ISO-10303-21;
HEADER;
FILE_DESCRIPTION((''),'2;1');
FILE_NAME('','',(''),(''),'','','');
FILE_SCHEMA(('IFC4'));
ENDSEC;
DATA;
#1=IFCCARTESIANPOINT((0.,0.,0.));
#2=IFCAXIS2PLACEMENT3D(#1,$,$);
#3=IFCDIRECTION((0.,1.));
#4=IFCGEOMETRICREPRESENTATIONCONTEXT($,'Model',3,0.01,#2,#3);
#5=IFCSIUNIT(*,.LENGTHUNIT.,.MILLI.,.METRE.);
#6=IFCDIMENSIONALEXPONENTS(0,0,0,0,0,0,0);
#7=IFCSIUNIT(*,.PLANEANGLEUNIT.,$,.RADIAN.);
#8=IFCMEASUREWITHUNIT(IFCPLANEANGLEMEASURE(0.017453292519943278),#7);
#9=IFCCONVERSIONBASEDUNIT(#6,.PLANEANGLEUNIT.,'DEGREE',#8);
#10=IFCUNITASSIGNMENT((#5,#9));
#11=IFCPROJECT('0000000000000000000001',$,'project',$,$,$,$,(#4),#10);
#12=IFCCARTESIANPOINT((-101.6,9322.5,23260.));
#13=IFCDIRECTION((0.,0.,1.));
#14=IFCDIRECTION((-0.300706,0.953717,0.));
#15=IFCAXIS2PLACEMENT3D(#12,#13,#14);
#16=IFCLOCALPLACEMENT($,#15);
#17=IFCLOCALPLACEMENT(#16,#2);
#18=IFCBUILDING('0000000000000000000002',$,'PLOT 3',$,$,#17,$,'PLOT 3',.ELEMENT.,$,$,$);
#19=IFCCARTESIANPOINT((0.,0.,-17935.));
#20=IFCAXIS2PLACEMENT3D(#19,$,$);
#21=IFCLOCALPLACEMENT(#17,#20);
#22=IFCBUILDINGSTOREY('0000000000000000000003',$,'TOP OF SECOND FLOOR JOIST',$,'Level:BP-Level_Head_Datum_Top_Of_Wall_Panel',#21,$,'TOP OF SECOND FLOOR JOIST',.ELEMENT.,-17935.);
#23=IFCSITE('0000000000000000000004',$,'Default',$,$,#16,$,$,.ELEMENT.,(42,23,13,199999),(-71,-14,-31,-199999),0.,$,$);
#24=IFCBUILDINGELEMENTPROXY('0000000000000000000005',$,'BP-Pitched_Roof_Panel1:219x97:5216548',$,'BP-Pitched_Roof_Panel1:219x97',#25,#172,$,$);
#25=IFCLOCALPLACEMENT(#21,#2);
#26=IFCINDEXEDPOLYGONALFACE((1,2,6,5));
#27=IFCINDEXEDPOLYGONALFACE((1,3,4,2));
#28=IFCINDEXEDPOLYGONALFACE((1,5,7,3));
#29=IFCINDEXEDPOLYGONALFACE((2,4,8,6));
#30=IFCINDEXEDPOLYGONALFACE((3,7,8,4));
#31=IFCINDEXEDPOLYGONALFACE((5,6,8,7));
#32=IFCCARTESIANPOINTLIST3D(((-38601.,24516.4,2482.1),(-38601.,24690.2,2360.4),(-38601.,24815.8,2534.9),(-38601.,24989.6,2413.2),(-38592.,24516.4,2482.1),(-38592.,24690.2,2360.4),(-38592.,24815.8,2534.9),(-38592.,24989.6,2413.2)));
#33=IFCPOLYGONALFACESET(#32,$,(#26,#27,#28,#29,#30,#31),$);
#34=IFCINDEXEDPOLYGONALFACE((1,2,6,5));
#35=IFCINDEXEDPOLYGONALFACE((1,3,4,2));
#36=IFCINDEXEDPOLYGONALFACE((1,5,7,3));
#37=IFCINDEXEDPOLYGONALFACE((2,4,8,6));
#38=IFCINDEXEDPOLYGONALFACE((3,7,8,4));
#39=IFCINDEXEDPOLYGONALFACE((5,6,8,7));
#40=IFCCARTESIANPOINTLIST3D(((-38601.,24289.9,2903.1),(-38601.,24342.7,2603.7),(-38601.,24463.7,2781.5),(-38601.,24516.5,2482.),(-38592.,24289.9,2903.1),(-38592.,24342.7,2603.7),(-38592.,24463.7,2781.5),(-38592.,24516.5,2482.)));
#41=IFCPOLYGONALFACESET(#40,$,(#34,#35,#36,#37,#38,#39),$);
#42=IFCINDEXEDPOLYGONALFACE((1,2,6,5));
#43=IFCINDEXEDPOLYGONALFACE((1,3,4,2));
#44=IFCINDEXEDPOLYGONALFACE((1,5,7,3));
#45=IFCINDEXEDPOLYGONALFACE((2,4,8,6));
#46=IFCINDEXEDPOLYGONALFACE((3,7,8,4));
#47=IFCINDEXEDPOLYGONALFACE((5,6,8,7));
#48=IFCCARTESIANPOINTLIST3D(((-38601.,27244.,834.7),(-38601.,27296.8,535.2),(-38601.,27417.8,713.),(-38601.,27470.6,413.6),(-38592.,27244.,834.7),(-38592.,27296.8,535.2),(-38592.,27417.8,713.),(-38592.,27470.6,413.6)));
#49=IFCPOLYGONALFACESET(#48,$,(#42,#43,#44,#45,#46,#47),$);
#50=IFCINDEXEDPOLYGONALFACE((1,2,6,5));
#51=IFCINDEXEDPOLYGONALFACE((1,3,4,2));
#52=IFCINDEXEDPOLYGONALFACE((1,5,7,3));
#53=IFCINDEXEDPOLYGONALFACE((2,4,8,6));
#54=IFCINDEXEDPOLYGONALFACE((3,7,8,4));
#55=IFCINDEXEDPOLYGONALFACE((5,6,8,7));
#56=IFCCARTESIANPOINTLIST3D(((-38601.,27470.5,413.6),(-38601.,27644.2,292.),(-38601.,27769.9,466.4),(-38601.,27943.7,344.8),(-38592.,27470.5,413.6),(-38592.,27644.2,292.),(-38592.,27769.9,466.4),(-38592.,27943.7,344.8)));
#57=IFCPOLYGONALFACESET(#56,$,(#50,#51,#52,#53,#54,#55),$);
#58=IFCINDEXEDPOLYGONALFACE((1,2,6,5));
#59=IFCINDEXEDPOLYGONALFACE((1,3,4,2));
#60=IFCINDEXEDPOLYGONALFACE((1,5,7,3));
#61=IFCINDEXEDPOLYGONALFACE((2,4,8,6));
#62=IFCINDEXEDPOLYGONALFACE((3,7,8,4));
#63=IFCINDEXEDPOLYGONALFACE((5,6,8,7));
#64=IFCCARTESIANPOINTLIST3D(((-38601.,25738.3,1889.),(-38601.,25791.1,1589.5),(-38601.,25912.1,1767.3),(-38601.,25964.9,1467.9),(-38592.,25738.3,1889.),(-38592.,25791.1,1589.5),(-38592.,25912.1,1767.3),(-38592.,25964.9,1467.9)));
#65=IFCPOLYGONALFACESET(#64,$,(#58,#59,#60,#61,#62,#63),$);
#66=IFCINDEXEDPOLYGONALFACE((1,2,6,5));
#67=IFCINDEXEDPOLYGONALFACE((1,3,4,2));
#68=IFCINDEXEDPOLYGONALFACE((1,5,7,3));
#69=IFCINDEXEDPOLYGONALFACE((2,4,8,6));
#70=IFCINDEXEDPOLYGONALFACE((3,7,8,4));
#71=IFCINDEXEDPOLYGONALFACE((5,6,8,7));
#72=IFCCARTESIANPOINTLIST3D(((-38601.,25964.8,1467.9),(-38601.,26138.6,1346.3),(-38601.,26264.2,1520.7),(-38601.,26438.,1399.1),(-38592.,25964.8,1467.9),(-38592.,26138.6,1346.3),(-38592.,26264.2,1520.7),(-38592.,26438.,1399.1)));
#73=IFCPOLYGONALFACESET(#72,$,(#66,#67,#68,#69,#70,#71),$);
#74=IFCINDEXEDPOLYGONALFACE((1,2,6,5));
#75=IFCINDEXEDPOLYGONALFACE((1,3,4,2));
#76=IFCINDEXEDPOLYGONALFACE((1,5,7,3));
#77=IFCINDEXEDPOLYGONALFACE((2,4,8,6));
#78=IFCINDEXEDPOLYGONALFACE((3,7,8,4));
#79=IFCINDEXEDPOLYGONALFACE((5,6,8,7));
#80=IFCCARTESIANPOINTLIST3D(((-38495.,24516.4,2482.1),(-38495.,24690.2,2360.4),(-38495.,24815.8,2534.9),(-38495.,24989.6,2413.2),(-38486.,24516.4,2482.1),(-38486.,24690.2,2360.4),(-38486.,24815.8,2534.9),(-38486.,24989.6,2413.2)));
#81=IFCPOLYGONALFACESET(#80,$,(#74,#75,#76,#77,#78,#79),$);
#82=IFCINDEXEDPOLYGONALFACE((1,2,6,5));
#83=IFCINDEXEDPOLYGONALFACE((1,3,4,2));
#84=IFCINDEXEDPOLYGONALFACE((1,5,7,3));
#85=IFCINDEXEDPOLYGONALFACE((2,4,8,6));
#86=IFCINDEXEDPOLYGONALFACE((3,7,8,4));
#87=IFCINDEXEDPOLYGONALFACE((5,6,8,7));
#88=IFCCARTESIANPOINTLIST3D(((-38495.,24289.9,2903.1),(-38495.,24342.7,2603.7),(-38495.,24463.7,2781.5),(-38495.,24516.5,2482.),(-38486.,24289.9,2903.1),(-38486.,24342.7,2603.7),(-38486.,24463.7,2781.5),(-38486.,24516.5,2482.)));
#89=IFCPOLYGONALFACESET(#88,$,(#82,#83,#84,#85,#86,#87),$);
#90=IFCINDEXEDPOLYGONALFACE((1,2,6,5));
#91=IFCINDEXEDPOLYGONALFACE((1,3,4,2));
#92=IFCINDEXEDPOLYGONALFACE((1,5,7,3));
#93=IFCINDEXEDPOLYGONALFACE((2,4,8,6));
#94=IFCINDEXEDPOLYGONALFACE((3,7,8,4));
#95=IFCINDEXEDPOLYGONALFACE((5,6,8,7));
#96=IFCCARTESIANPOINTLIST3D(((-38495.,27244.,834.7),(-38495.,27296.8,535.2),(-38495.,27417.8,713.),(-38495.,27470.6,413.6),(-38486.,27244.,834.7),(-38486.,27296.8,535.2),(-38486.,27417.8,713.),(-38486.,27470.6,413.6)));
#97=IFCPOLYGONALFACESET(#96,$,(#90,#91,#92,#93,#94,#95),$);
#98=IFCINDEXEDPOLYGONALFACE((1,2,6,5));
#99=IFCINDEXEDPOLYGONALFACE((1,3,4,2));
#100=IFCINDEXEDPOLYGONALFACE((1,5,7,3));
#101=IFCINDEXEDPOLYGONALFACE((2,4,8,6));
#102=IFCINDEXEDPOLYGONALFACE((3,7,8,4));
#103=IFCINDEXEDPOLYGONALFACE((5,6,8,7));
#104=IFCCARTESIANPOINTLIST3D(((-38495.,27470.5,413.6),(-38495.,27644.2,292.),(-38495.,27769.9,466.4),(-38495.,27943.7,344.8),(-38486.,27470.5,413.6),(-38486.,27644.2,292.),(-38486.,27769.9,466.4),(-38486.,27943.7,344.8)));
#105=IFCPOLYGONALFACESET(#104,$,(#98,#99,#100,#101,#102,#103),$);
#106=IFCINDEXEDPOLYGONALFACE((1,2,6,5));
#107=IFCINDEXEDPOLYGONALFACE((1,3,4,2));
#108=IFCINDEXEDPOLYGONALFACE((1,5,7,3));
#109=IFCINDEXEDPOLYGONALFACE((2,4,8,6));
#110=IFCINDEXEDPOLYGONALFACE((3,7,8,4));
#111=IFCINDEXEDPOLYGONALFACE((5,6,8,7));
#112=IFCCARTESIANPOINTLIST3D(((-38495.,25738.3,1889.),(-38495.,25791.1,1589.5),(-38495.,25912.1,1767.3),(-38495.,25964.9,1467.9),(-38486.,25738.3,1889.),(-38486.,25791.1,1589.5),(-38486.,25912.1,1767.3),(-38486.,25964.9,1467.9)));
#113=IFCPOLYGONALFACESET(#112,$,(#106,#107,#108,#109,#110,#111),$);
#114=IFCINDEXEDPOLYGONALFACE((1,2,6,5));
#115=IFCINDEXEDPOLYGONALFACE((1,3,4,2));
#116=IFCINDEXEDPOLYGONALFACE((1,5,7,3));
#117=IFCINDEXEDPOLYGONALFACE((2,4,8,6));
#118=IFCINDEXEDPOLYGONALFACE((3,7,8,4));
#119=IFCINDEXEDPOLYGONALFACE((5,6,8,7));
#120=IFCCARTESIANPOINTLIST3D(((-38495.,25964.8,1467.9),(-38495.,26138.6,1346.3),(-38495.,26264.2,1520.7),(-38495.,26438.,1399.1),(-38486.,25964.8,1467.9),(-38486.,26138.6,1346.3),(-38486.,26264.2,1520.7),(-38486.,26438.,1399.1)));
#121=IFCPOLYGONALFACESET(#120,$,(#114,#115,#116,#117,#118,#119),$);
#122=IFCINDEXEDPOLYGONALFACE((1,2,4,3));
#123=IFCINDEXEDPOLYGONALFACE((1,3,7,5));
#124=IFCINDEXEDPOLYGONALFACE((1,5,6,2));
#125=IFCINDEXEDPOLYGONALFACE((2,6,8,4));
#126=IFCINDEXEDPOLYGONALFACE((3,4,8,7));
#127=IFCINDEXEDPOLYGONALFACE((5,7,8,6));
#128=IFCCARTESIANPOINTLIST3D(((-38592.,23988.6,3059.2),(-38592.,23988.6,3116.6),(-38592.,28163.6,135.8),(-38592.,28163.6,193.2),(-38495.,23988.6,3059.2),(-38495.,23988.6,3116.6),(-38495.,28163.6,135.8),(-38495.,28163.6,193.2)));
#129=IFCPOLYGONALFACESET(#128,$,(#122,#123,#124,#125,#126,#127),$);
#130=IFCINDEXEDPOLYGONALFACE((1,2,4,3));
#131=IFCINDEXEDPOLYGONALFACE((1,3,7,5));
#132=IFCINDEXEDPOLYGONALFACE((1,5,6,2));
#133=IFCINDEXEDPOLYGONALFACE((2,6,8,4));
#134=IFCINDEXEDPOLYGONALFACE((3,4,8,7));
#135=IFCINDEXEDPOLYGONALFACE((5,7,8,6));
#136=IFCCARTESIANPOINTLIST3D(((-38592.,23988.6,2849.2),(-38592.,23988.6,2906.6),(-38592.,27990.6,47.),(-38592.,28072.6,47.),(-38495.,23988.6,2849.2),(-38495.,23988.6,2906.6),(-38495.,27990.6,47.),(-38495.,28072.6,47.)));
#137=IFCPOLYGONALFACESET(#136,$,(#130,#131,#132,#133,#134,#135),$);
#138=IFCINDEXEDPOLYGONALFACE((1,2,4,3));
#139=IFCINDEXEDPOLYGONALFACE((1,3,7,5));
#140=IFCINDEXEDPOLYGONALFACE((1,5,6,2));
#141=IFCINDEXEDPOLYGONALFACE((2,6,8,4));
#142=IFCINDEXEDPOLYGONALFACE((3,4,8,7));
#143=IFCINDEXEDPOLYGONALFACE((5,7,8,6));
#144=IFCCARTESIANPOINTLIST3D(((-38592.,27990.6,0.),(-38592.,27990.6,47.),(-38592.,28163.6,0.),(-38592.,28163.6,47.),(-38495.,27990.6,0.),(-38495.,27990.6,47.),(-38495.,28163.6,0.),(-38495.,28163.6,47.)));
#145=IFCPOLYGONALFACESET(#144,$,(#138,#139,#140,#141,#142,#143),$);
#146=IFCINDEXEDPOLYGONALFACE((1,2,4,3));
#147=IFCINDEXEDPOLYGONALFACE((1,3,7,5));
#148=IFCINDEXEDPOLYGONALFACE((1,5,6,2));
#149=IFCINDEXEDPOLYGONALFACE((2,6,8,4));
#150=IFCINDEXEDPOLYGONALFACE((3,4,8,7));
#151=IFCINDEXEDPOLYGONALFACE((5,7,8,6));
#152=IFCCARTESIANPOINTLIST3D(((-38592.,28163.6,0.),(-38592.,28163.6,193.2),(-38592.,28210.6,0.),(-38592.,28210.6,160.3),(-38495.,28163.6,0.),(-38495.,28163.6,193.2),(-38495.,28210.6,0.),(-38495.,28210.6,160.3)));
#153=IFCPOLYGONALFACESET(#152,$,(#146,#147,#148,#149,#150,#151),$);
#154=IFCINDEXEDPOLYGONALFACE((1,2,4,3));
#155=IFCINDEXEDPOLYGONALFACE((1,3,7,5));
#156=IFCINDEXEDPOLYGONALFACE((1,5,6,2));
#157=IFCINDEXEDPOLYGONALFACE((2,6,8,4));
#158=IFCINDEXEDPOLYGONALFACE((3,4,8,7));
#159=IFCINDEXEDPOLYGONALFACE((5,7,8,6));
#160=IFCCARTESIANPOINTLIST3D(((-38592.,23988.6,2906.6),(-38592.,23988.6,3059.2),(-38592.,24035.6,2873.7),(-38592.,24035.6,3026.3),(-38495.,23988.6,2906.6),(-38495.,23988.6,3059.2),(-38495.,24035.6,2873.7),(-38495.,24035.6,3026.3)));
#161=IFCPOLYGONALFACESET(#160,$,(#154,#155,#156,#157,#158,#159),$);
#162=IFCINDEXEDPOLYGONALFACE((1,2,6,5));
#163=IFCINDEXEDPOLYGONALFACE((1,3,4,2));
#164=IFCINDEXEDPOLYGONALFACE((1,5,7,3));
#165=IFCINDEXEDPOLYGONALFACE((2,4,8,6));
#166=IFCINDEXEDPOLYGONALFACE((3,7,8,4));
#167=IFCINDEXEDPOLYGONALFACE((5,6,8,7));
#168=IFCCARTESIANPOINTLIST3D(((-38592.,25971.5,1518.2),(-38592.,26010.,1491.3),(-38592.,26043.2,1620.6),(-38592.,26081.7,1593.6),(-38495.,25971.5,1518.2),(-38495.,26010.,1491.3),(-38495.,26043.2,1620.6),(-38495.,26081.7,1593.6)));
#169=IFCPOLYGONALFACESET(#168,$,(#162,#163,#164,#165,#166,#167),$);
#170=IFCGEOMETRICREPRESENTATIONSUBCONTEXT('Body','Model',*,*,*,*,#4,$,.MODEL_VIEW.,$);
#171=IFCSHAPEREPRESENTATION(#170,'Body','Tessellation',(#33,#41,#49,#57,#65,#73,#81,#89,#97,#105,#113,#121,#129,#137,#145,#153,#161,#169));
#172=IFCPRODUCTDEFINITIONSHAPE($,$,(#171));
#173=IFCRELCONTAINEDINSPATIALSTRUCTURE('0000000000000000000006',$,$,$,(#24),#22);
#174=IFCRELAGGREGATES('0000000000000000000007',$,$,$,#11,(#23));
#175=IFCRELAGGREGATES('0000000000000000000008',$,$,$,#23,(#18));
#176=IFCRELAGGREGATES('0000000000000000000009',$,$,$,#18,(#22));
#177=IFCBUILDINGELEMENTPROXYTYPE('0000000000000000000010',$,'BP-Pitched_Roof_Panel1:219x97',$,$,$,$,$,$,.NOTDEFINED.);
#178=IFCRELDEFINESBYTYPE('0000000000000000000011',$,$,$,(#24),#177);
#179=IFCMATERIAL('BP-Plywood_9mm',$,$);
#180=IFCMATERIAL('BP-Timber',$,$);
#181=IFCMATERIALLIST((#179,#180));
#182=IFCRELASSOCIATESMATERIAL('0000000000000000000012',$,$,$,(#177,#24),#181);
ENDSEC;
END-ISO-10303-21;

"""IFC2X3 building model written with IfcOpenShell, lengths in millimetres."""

from ifc_helpers import new_model, entity, si_unit, converted_unit, direction, frame, frame_2d, origin, origin_2d_with_axis, place, context, subcontext, project, spatial, polyline, rectangle, outline, extrude, source, transform, mapped, material, material_list, type_object, type_shapes, element, save


model = new_model("IFC2X3")

# Units and contexts
model_context = context("Model", 3, precision=0.01, world=origin(), true_north=direction((0.0, 1.0)))
body_context = subcontext(model_context, "Body", "Model", "MODEL_VIEW")
ifc_project = project(units=[si_unit("LENGTHUNIT", "METRE", prefix="MILLI"), converted_unit("PLANEANGLEUNIT", "DEGREE", entity("IfcPlaneAngleMeasure", 0.017453292519943278), si_unit("PLANEANGLEUNIT", "RADIAN"), dimensions=[0, 0, 0, 0, 0, 0, 0])], contexts=[model_context])

# Site, building, storey
site_placement = place(None, frame((-101.6, 9322.5, 23260.0), z_axis=(0.0, 0.0, 1.0), x_axis=(-0.300706, 0.953717, 0.0)))
site = spatial("IfcSite", under=ifc_project, at=site_placement, Name="Default", CompositionType="ELEMENT", RefLatitude=(42, 23, 13, 199999), RefLongitude=(-71, -14, -31, -199999), RefElevation=0.0)
building_placement = place(site_placement, origin())
building = spatial("IfcBuilding", under=site, at=building_placement, Name="PLOT 3", LongName="PLOT 3", CompositionType="ELEMENT")
storey_placement = place(building_placement, frame((0.0, 0.0, -17935.0)))
storey = spatial("IfcBuildingStorey", under=building, at=storey_placement, Name="TOP OF SECOND FLOOR JOIST", ObjectType="Level:BP-Level_Head_Datum_Top_Of_Wall_Panel", LongName="TOP OF SECOND FLOOR JOIST", CompositionType="ELEMENT", Elevation=-17935.0)

# Building element proxy
ifc_material_1 = material(Name="BP-Timber")
ifc_material_2 = material(Name="BP-Plywood_9mm")
ifc_material_list = material_list([ifc_material_2, ifc_material_1])
building_element_proxy_type_1 = type_object("IfcBuildingElementProxyType", Name="BP-Pitched_Roof_Panel1:219x97", PredefinedType="NOTDEFINED", material=ifc_material_list)
shared_shape_1 = source(origin(), body_context, "Body", "SweptSolid", [
    extrude(outline(polyline([(-77.0, -75.0), (227.0, -75.0), (77.0, 75.0), (-227.0, 75.0), (-77.0, -75.0)])), frame((35.3, -3956.0, 2447.7), z_axis=(0.0, 1.0, 0.0), x_axis=(-0.984808, 0.0, 0.173648)), (0.0, 0.0, 1.0), 9.0),
    extrude(outline(polyline([(1.4, -107.5), (213.6, -107.5), (-1.4, 107.5), (-213.6, 107.5), (1.4, -107.5)])), frame((385.1, -3956.0, 2692.6), z_axis=(0.0, 1.0, 0.0), x_axis=(-0.819152, 0.0, -0.573576)), (0.0, 0.0, 1.0), 9.0),
    extrude(outline(polyline([(1.4, -107.5), (213.6, -107.5), (-1.4, 107.5), (-213.6, 107.5), (1.4, -107.5)])), frame((-2569.0, -3956.0, 624.1), z_axis=(0.0, 1.0, 0.0), x_axis=(-0.819152, 0.0, -0.573576)), (0.0, 0.0, 1.0), 9.0),
    extrude(outline(polyline([(-77.0, -75.0), (227.0, -75.0), (77.0, 75.0), (-227.0, 75.0), (-77.0, -75.0)])), frame((-2918.8, -3956.0, 379.2), z_axis=(0.0, 1.0, 0.0), x_axis=(-0.984808, 0.0, 0.173648)), (0.0, 0.0, 1.0), 9.0),
    extrude(outline(polyline([(1.4, -107.5), (213.6, -107.5), (-1.4, 107.5), (-213.6, 107.5), (1.4, -107.5)])), frame((-1063.3, -3956.0, 1678.4), z_axis=(0.0, 1.0, 0.0), x_axis=(-0.819152, 0.0, -0.573576)), (0.0, 0.0, 1.0), 9.0),
    extrude(outline(polyline([(-77.0, -75.0), (227.0, -75.0), (77.0, 75.0), (-227.0, 75.0), (-77.0, -75.0)])), frame((-1413.1, -3956.0, 1433.5), z_axis=(0.0, 1.0, 0.0), x_axis=(-0.984808, 0.0, 0.173648)), (0.0, 0.0, 1.0), 9.0),
    extrude(outline(polyline([(-77.0, -75.0), (227.0, -75.0), (77.0, 75.0), (-227.0, 75.0), (-77.0, -75.0)])), frame((35.3, -3850.0, 2447.7), z_axis=(0.0, 1.0, 0.0), x_axis=(-0.984808, 0.0, 0.173648)), (0.0, 0.0, 1.0), 9.0),
    extrude(outline(polyline([(1.4, -107.5), (213.6, -107.5), (-1.4, 107.5), (-213.6, 107.5), (1.4, -107.5)])), frame((385.1, -3850.0, 2692.6), z_axis=(0.0, 1.0, 0.0), x_axis=(-0.819152, 0.0, -0.573576)), (0.0, 0.0, 1.0), 9.0),
    extrude(outline(polyline([(1.4, -107.5), (213.6, -107.5), (-1.4, 107.5), (-213.6, 107.5), (1.4, -107.5)])), frame((-2569.0, -3850.0, 624.1), z_axis=(0.0, 1.0, 0.0), x_axis=(-0.819152, 0.0, -0.573576)), (0.0, 0.0, 1.0), 9.0),
    extrude(outline(polyline([(-77.0, -75.0), (227.0, -75.0), (77.0, 75.0), (-227.0, 75.0), (-77.0, -75.0)])), frame((-2918.8, -3850.0, 379.2), z_axis=(0.0, 1.0, 0.0), x_axis=(-0.984808, 0.0, 0.173648)), (0.0, 0.0, 1.0), 9.0),
    extrude(outline(polyline([(1.4, -107.5), (213.6, -107.5), (-1.4, 107.5), (-213.6, 107.5), (1.4, -107.5)])), frame((-1063.3, -3850.0, 1678.4), z_axis=(0.0, 1.0, 0.0), x_axis=(-0.819152, 0.0, -0.573576)), (0.0, 0.0, 1.0), 9.0),
    extrude(outline(polyline([(-77.0, -75.0), (227.0, -75.0), (77.0, 75.0), (-227.0, 75.0), (-77.0, -75.0)])), frame((-1413.1, -3850.0, 1433.5), z_axis=(0.0, 1.0, 0.0), x_axis=(-0.984808, 0.0, 0.173648)), (0.0, 0.0, 1.0), 9.0),
    extrude(outline(polyline([(-1490.4, -2087.5), (-1433.0, -2087.5), (1490.4, 2087.5), (1433.0, 2087.5), (-1490.4, -2087.5)])), frame((-1287.8, -3947.0, 1626.2), z_axis=(0.0, 1.0, 0.0), x_axis=(0.0, 0.0, -1.0)), (0.0, 0.0, 1.0), 97.0),
    extrude(outline(polyline([(-1444.1, -2021.5), (-1386.8, -2021.5), (1415.5, 1980.5), (1415.5, 2062.5), (-1444.1, -2021.5)])), frame((-1221.8, -3947.0, 1462.5), z_axis=(0.0, 1.0, 0.0), x_axis=(0.0, 0.0, -1.0)), (0.0, 0.0, 1.0), 97.0),
    extrude(rectangle(XDim=173.0, YDim=97.0, at=origin_2d_with_axis()), frame((-3288.8, -3898.5, 0.0), z_axis=(0.0, 0.0, 1.0), x_axis=(-1.0, 0.0, 0.0)), (0.0, 0.0, 1.0), 47.0),
    extrude(outline(polyline([(22.0, -72.4), (79.4, -72.4), (-31.4, 85.9), (-69.9, 58.9), (22.0, -72.4)])), frame((-3398.8, -3947.0, 88.4), z_axis=(0.0, 1.0, 0.0), x_axis=(0.819152, 0.0, 0.573576)), (0.0, 0.0, 1.0), 97.0),
    extrude(outline(polyline([(15.1, -62.5), (72.5, -62.5), (-15.1, 62.5), (-72.5, 62.5), (15.1, -62.5)])), frame((776.2, -3947.0, 2966.5), z_axis=(0.0, 1.0, 0.0), x_axis=(0.819152, 0.0, 0.573576)), (0.0, 0.0, 1.0), 97.0),
    extrude(rectangle(XDim=47.0, YDim=97.0, at=frame_2d((0.0, 0.0), x_axis=(1.0, 0.0))), frame((-1202.4, -3898.5, 1504.7), z_axis=(-0.573576, 0.0, 0.819152), x_axis=(-0.819152, 0.0, -0.573576)), (0.0, 0.0, 1.0), 125.0),
])
type_shapes(building_element_proxy_type_1, [shared_shape_1])
for number, where, z_axis, x_axis, name in (
    (1, (-34645.0, 24788.3, 0.0), (0.0, 0.0, 1.0), (0.0, -1.0, 0.0), "BP-Pitched_Roof_Panel1:219x97:5216548"),
):
    element("IfcBuildingElementProxy", number, at=place(storey_placement, frame(where, z_axis=z_axis, x_axis=x_axis)), inside=storey, type_object=building_element_proxy_type_1, material=ifc_material_list, Name=name, ObjectType="BP-Pitched_Roof_Panel1:219x97", context=body_context, shape_type="MappedRepresentation", body=[
        mapped(shared_shape_1, transform((0.0, 0.0, 0.0), scale=1.0)),
    ])

save(model, "model.ifc")
